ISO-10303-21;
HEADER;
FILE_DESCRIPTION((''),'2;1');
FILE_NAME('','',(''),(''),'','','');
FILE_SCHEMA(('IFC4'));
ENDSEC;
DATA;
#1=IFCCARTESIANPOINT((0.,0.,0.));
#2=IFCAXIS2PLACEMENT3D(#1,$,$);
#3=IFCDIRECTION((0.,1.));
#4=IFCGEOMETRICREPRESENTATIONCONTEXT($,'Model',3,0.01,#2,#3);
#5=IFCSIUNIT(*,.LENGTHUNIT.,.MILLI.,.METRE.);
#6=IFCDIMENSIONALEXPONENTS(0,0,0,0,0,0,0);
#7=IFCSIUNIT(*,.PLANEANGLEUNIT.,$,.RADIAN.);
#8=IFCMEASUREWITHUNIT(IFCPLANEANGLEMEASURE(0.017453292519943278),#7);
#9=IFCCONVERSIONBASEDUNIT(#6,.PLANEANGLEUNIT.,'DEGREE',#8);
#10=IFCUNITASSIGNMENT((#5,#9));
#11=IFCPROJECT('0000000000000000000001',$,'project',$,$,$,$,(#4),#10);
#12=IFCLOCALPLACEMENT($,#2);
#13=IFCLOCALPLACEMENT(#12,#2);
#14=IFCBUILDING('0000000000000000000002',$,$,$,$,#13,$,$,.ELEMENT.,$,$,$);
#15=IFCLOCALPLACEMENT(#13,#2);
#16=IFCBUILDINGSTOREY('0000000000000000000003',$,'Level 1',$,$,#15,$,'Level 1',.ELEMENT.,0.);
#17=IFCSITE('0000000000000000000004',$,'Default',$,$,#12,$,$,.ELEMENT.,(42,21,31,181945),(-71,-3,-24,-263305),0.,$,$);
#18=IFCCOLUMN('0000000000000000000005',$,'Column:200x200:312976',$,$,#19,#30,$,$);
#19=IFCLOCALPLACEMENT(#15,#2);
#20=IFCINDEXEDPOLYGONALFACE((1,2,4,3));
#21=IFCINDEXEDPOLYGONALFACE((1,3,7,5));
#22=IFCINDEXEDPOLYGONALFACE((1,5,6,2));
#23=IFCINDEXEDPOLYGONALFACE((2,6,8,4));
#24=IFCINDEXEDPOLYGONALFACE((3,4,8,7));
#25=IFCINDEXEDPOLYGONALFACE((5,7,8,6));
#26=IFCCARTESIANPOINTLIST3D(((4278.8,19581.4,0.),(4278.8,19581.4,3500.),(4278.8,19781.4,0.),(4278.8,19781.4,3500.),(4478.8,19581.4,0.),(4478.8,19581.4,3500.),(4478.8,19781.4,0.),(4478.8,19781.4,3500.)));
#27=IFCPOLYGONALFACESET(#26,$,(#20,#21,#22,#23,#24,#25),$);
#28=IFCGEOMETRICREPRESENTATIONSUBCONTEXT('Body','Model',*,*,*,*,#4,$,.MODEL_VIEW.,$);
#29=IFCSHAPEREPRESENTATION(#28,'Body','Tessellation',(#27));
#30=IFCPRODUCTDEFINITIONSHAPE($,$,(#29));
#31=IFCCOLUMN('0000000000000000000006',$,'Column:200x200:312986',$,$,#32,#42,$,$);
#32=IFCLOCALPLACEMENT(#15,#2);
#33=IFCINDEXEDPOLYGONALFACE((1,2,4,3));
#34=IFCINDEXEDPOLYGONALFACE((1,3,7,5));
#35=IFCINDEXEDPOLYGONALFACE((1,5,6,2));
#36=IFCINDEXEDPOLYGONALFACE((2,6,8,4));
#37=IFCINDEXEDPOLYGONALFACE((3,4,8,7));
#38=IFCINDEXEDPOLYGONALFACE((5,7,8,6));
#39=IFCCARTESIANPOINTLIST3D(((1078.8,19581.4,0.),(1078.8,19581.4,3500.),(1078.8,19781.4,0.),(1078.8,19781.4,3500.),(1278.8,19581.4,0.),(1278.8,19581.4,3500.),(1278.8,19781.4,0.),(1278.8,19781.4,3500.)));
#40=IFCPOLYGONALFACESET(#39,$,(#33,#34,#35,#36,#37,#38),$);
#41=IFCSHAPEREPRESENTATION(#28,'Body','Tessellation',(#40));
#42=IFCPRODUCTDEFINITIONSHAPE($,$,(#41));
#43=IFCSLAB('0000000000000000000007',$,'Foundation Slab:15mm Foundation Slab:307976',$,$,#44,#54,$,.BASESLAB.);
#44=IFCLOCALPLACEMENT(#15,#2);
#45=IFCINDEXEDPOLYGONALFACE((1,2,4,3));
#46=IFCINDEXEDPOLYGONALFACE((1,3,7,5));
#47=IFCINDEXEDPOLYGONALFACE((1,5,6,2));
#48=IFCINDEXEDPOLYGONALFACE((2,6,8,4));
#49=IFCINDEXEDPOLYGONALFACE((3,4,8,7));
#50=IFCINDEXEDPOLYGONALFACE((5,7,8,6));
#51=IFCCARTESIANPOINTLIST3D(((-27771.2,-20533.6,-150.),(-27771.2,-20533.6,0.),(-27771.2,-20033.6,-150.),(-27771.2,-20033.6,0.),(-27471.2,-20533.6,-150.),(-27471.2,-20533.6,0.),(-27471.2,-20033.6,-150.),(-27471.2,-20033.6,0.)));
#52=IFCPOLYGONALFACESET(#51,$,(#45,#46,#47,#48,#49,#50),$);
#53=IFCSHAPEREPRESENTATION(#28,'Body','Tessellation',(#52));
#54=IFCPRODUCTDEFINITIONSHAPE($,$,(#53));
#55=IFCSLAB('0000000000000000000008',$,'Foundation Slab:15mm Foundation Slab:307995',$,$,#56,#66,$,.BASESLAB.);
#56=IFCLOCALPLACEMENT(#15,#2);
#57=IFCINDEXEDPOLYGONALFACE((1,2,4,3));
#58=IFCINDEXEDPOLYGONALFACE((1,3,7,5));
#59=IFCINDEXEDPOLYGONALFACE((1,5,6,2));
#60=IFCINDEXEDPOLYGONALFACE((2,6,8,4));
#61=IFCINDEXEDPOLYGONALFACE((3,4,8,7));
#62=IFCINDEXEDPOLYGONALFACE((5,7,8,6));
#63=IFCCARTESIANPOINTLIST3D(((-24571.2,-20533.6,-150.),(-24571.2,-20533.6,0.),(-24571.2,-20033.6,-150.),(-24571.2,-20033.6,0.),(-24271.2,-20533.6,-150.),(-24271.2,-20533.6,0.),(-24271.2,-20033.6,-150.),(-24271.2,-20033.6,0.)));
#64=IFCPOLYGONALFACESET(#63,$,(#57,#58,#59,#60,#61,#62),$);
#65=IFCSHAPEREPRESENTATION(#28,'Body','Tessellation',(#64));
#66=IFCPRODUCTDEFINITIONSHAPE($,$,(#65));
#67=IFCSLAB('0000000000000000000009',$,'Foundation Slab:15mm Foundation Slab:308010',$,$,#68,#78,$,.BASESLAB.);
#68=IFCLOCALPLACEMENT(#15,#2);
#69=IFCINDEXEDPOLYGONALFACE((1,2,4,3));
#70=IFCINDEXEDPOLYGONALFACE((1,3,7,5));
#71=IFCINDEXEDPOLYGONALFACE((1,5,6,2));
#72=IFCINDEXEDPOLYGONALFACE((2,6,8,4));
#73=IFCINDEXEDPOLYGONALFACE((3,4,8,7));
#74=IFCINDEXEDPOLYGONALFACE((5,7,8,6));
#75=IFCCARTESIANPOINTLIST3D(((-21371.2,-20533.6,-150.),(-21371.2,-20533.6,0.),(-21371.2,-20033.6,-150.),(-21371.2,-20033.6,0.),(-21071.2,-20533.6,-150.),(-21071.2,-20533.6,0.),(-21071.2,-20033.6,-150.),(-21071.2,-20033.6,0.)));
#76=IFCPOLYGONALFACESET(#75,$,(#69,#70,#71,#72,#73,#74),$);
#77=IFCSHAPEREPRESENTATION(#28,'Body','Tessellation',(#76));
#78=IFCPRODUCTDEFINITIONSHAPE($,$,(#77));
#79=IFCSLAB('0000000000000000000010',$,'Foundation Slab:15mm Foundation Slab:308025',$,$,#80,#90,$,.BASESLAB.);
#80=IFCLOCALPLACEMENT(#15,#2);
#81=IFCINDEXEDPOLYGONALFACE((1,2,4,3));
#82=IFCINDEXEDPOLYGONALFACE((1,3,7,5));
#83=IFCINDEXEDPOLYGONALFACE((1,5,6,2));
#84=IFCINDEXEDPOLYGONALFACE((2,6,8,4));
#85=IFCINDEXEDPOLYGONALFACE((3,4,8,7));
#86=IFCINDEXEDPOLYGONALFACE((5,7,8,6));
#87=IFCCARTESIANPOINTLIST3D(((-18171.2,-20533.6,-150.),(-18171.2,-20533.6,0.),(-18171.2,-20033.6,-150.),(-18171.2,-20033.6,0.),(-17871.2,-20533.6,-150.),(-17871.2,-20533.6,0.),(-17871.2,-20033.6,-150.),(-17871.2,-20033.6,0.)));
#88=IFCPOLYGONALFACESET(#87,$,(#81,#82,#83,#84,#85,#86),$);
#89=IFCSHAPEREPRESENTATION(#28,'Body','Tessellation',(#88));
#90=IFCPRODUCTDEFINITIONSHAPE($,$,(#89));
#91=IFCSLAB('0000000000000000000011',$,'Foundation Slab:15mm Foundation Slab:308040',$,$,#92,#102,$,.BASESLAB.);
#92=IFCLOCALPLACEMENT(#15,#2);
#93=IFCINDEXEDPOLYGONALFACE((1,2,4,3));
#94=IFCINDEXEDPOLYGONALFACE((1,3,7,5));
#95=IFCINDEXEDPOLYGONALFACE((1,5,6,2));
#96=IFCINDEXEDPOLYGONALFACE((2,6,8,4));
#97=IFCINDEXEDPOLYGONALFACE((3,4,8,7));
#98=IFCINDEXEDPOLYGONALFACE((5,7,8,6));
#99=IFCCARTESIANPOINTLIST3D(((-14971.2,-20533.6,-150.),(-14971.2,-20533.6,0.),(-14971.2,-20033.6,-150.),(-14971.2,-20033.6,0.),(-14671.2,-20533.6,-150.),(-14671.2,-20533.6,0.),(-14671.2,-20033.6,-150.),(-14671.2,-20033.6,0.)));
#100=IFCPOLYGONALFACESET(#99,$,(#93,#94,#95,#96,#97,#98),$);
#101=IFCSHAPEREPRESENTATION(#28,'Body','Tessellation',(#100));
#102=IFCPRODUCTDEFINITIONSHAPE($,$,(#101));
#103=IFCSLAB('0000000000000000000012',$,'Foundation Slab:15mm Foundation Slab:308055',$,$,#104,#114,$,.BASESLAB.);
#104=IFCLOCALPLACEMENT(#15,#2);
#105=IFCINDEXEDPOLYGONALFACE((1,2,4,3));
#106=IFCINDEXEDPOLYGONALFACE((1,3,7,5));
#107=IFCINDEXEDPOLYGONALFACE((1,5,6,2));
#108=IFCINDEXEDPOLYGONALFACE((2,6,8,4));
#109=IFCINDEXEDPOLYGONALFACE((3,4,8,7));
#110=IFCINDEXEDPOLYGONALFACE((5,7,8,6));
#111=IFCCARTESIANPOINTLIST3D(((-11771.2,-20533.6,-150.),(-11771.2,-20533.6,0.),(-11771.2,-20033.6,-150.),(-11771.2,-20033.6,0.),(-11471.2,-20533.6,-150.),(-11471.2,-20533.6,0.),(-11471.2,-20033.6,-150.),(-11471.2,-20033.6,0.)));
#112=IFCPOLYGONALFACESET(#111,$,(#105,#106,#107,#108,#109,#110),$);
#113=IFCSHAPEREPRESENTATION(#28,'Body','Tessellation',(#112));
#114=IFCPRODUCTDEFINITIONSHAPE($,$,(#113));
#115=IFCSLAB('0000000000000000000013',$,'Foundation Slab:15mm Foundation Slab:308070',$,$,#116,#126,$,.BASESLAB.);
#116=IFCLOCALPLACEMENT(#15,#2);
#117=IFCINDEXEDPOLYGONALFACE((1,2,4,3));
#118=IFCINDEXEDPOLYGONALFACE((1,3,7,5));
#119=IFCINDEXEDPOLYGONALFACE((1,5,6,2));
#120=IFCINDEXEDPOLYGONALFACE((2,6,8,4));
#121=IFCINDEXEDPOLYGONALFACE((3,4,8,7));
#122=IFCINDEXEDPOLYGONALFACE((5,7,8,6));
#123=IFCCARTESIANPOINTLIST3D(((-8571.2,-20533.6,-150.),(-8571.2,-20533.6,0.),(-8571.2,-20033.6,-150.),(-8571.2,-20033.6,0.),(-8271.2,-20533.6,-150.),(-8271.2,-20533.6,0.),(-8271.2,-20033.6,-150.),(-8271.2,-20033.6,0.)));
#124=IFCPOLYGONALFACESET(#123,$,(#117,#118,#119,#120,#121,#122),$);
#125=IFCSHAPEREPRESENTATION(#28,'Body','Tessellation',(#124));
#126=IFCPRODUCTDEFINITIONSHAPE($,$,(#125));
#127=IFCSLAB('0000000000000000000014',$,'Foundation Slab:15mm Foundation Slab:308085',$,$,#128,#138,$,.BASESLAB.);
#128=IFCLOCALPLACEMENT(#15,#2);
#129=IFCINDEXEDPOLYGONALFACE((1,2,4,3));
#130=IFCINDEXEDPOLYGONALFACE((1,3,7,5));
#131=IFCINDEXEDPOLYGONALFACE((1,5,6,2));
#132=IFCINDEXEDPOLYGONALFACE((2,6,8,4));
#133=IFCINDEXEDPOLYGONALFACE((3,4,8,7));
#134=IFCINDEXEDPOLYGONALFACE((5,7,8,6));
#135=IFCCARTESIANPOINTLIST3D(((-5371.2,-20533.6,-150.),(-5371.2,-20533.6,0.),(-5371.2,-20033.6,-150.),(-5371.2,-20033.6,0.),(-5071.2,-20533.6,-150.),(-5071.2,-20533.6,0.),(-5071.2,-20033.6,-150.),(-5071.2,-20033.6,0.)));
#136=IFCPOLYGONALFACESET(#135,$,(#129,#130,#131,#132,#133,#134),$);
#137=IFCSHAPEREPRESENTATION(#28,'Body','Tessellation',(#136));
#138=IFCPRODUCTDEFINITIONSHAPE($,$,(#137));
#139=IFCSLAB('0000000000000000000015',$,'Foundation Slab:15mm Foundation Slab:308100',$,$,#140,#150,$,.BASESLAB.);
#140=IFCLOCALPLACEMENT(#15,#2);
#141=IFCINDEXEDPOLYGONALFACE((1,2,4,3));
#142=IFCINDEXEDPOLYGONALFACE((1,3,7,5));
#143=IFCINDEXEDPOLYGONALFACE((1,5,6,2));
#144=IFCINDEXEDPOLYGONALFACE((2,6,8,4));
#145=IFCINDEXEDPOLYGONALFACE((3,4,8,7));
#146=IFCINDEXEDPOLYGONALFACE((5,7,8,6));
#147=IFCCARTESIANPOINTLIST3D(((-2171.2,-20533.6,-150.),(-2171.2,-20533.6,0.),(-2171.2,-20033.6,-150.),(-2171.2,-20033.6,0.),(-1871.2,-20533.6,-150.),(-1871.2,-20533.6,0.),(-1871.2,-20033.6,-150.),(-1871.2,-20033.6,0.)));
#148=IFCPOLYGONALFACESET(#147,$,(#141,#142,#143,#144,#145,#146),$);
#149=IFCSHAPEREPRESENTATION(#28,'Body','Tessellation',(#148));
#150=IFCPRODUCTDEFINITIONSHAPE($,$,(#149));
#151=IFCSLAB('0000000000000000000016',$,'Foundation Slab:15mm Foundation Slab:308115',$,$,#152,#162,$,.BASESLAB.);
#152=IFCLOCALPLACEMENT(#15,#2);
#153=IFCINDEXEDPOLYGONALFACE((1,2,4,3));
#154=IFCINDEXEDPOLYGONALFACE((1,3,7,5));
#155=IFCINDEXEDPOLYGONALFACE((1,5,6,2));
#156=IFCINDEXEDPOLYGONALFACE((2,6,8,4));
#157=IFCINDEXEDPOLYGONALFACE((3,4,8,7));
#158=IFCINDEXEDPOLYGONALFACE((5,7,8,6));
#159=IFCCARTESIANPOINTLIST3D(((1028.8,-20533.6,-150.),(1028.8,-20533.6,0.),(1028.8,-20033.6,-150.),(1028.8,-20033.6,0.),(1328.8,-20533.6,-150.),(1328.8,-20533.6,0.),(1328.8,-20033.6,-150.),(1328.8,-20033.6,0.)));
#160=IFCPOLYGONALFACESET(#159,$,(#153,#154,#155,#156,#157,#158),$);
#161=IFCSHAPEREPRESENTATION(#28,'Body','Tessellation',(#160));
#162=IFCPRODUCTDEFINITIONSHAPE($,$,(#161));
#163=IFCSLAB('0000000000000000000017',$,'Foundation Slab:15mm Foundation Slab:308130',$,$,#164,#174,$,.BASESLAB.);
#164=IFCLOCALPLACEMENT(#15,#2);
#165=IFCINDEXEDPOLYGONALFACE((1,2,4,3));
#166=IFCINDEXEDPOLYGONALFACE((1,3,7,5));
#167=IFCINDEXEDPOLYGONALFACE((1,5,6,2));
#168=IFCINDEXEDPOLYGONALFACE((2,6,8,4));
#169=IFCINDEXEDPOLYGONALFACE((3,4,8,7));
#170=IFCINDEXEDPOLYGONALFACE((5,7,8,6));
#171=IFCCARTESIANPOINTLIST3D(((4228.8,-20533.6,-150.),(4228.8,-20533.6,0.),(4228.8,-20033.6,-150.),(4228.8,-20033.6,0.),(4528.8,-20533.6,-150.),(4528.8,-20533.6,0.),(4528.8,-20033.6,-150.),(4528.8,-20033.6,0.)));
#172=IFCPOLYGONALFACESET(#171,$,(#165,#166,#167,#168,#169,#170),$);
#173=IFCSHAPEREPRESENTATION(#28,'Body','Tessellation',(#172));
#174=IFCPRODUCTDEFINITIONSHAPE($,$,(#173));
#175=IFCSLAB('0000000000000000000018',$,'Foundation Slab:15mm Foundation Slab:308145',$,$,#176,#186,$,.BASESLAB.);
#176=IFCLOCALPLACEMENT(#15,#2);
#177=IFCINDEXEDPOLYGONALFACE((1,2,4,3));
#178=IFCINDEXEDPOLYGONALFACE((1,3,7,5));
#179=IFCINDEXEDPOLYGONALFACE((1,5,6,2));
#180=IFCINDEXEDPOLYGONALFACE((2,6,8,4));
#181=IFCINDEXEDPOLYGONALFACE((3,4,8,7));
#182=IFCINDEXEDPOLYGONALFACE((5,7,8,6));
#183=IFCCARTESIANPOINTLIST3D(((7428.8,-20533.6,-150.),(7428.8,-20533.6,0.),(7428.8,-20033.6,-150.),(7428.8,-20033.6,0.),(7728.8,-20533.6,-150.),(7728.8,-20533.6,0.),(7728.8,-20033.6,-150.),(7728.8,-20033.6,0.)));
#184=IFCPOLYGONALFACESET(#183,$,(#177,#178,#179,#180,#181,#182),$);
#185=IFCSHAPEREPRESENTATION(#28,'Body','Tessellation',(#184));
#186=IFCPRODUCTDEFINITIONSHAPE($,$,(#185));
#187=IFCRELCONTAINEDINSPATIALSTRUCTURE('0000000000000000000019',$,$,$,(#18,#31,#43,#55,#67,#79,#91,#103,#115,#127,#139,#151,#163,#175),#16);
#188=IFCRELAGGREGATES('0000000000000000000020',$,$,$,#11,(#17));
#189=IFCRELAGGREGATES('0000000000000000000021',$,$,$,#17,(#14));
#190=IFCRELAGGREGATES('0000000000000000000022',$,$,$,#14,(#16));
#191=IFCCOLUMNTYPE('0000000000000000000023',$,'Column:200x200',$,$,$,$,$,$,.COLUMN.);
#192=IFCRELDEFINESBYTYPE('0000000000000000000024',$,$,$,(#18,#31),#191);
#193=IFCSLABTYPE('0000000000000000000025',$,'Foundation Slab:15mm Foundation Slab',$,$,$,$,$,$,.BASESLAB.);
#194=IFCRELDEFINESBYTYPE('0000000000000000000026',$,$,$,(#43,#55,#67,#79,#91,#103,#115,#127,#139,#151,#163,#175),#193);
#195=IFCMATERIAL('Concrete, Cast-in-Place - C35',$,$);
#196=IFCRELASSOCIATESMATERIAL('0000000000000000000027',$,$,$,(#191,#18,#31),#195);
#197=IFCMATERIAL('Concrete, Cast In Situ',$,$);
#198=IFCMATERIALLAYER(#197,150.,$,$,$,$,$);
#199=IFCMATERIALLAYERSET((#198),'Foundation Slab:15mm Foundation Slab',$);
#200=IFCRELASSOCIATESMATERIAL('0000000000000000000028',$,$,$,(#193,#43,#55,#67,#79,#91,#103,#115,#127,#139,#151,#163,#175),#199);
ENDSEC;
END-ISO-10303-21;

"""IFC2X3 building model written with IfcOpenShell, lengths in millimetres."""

from ifc_helpers import new_model, entity, si_unit, converted_unit, direction, frame, frame_2d, origin, origin_2d_with_axis, place, context, subcontext, project, spatial, rectangle, extrude, source, transform, mapped, material, layer, layer_set, layer_usage, type_object, type_shapes, element, save


model = new_model("IFC2X3")

# Units and contexts
model_context = context("Model", 3, precision=0.01, world=origin(), true_north=direction((0.0, 1.0)))
body_context = subcontext(model_context, "Body", "Model", "MODEL_VIEW")
ifc_project = project(units=[si_unit("LENGTHUNIT", "METRE", prefix="MILLI"), converted_unit("PLANEANGLEUNIT", "DEGREE", entity("IfcPlaneAngleMeasure", 0.017453292519943278), si_unit("PLANEANGLEUNIT", "RADIAN"), dimensions=[0, 0, 0, 0, 0, 0, 0])], contexts=[model_context])

# Site, building, storey
site_placement = place(None, origin())
site = spatial("IfcSite", under=ifc_project, at=site_placement, Name="Default", CompositionType="ELEMENT", RefLatitude=(42, 21, 31, 181945), RefLongitude=(-71, -3, -24, -263305), RefElevation=0.0)
building_placement = place(site_placement, origin())
building = spatial("IfcBuilding", under=site, at=building_placement, CompositionType="ELEMENT")
storey_placement = place(building_placement, origin())
storey = spatial("IfcBuildingStorey", under=building, at=storey_placement, Name="Level 1", LongName="Level 1", CompositionType="ELEMENT", Elevation=0.0)

# Columns
ifc_material_1 = material(Name="Concrete, Cast-in-Place - C35")
column_type_1 = type_object("IfcColumnType", Name="Column:200x200", PredefinedType="COLUMN", material=ifc_material_1)
shared_shape_1 = source(origin(), body_context, "Body", "SweptSolid", [
    extrude(rectangle(XDim=200.0, YDim=200.0, at=frame_2d((0.0, 0.0), x_axis=(1.0, 0.0))), frame((0.0, 0.0, 0.0), z_axis=(0.0, 0.0, 1.0), x_axis=(-1.0, 0.0, 0.0)), (0.0, 0.0, 1.0), 3500.0),
])
type_shapes(column_type_1, [shared_shape_1])
for number, where, name in (
    (1, (4378.8, 19681.4, 0.0), "Column:200x200:312976"),
    (2, (1178.8, 19681.4, 0.0), "Column:200x200:312986"),
):
    element("IfcColumn", number, at=place(storey_placement, frame(where)), inside=storey, type_object=column_type_1, material=ifc_material_1, Name=name, context=body_context, shape_type="MappedRepresentation", body=[
        mapped(shared_shape_1, transform((0.0, 0.0, 0.0), scale=1.0)),
    ])

# Slabs
ifc_material_2 = material(Name="Concrete, Cast In Situ")
ifc_layer = layer(ifc_material_2, 150.0)
ifc_layer_set = layer_set([ifc_layer], Name="Foundation Slab:15mm Foundation Slab")
ifc_layer_usage_1 = layer_usage(ifc_layer_set, "AXIS3", "POSITIVE", 0.0)
slab_type = type_object("IfcSlabType", Name="Foundation Slab:15mm Foundation Slab", PredefinedType="BASESLAB", material=ifc_layer_set)
slab_1_placement = place(storey_placement, origin())
element("IfcSlab", 3, at=slab_1_placement, inside=storey, type_object=slab_type, material=ifc_layer_usage_1, Name="Foundation Slab:15mm Foundation Slab:307976", PredefinedType="BASESLAB", context=body_context, shape_type="SweptSolid", body=[
    extrude(rectangle(XDim=500.0, YDim=300.0, at=origin_2d_with_axis()), frame((-27621.2, -20283.6, 0.0), z_axis=(0.0, 0.0, -1.0), x_axis=(0.0, 1.0, 0.0)), (0.0, 0.0, 1.0), 150.0),
])
ifc_layer_usage_2 = layer_usage(ifc_layer_set, "AXIS3", "POSITIVE", 0.0)
slab_2_placement = place(storey_placement, origin())
element("IfcSlab", 4, at=slab_2_placement, inside=storey, type_object=slab_type, material=ifc_layer_usage_2, Name="Foundation Slab:15mm Foundation Slab:307995", PredefinedType="BASESLAB", context=body_context, shape_type="SweptSolid", body=[
    extrude(rectangle(XDim=500.0, YDim=300.0, at=origin_2d_with_axis()), frame((-24421.2, -20283.6, 0.0), z_axis=(0.0, 0.0, -1.0), x_axis=(0.0, 1.0, 0.0)), (0.0, 0.0, 1.0), 150.0),
])
ifc_layer_usage_3 = layer_usage(ifc_layer_set, "AXIS3", "POSITIVE", 0.0)
slab_3_placement = place(storey_placement, origin())
element("IfcSlab", 5, at=slab_3_placement, inside=storey, type_object=slab_type, material=ifc_layer_usage_3, Name="Foundation Slab:15mm Foundation Slab:308010", PredefinedType="BASESLAB", context=body_context, shape_type="SweptSolid", body=[
    extrude(rectangle(XDim=500.0, YDim=300.0, at=origin_2d_with_axis()), frame((-21221.2, -20283.6, 0.0), z_axis=(0.0, 0.0, -1.0), x_axis=(0.0, 1.0, 0.0)), (0.0, 0.0, 1.0), 150.0),
])
ifc_layer_usage_4 = layer_usage(ifc_layer_set, "AXIS3", "POSITIVE", 0.0)
slab_4_placement = place(storey_placement, origin())
element("IfcSlab", 6, at=slab_4_placement, inside=storey, type_object=slab_type, material=ifc_layer_usage_4, Name="Foundation Slab:15mm Foundation Slab:308025", PredefinedType="BASESLAB", context=body_context, shape_type="SweptSolid", body=[
    extrude(rectangle(XDim=500.0, YDim=300.0, at=origin_2d_with_axis()), frame((-18021.2, -20283.6, 0.0), z_axis=(0.0, 0.0, -1.0), x_axis=(0.0, 1.0, 0.0)), (0.0, 0.0, 1.0), 150.0),
])
ifc_layer_usage_5 = layer_usage(ifc_layer_set, "AXIS3", "POSITIVE", 0.0)
slab_5_placement = place(storey_placement, origin())
element("IfcSlab", 7, at=slab_5_placement, inside=storey, type_object=slab_type, material=ifc_layer_usage_5, Name="Foundation Slab:15mm Foundation Slab:308040", PredefinedType="BASESLAB", context=body_context, shape_type="SweptSolid", body=[
    extrude(rectangle(XDim=500.0, YDim=300.0, at=origin_2d_with_axis()), frame((-14821.2, -20283.6, 0.0), z_axis=(0.0, 0.0, -1.0), x_axis=(0.0, 1.0, 0.0)), (0.0, 0.0, 1.0), 150.0),
])
ifc_layer_usage_6 = layer_usage(ifc_layer_set, "AXIS3", "POSITIVE", 0.0)
slab_6_placement = place(storey_placement, origin())
element("IfcSlab", 8, at=slab_6_placement, inside=storey, type_object=slab_type, material=ifc_layer_usage_6, Name="Foundation Slab:15mm Foundation Slab:308055", PredefinedType="BASESLAB", context=body_context, shape_type="SweptSolid", body=[
    extrude(rectangle(XDim=500.0, YDim=300.0, at=origin_2d_with_axis()), frame((-11621.2, -20283.6, 0.0), z_axis=(0.0, 0.0, -1.0), x_axis=(0.0, 1.0, 0.0)), (0.0, 0.0, 1.0), 150.0),
])
ifc_layer_usage_7 = layer_usage(ifc_layer_set, "AXIS3", "POSITIVE", 0.0)
slab_7_placement = place(storey_placement, origin())
element("IfcSlab", 9, at=slab_7_placement, inside=storey, type_object=slab_type, material=ifc_layer_usage_7, Name="Foundation Slab:15mm Foundation Slab:308070", PredefinedType="BASESLAB", context=body_context, shape_type="SweptSolid", body=[
    extrude(rectangle(XDim=500.0, YDim=300.0, at=origin_2d_with_axis()), frame((-8421.2, -20283.6, 0.0), z_axis=(0.0, 0.0, -1.0), x_axis=(0.0, 1.0, 0.0)), (0.0, 0.0, 1.0), 150.0),
])
ifc_layer_usage_8 = layer_usage(ifc_layer_set, "AXIS3", "POSITIVE", 0.0)
slab_8_placement = place(storey_placement, origin())
element("IfcSlab", 10, at=slab_8_placement, inside=storey, type_object=slab_type, material=ifc_layer_usage_8, Name="Foundation Slab:15mm Foundation Slab:308085", PredefinedType="BASESLAB", context=body_context, shape_type="SweptSolid", body=[
    extrude(rectangle(XDim=500.0, YDim=300.0, at=origin_2d_with_axis()), frame((-5221.2, -20283.6, 0.0), z_axis=(0.0, 0.0, -1.0), x_axis=(0.0, 1.0, 0.0)), (0.0, 0.0, 1.0), 150.0),
])
ifc_layer_usage_9 = layer_usage(ifc_layer_set, "AXIS3", "POSITIVE", 0.0)
slab_9_placement = place(storey_placement, origin())
element("IfcSlab", 11, at=slab_9_placement, inside=storey, type_object=slab_type, material=ifc_layer_usage_9, Name="Foundation Slab:15mm Foundation Slab:308100", PredefinedType="BASESLAB", context=body_context, shape_type="SweptSolid", body=[
    extrude(rectangle(XDim=500.0, YDim=300.0, at=origin_2d_with_axis()), frame((-2021.2, -20283.6, 0.0), z_axis=(0.0, 0.0, -1.0), x_axis=(0.0, 1.0, 0.0)), (0.0, 0.0, 1.0), 150.0),
])
ifc_layer_usage_10 = layer_usage(ifc_layer_set, "AXIS3", "POSITIVE", 0.0)
slab_10_placement = place(storey_placement, origin())
element("IfcSlab", 12, at=slab_10_placement, inside=storey, type_object=slab_type, material=ifc_layer_usage_10, Name="Foundation Slab:15mm Foundation Slab:308115", PredefinedType="BASESLAB", context=body_context, shape_type="SweptSolid", body=[
    extrude(rectangle(XDim=500.0, YDim=300.0, at=origin_2d_with_axis()), frame((1178.8, -20283.6, 0.0), z_axis=(0.0, 0.0, -1.0), x_axis=(0.0, 1.0, 0.0)), (0.0, 0.0, 1.0), 150.0),
])
ifc_layer_usage_11 = layer_usage(ifc_layer_set, "AXIS3", "POSITIVE", 0.0)
slab_11_placement = place(storey_placement, origin())
element("IfcSlab", 13, at=slab_11_placement, inside=storey, type_object=slab_type, material=ifc_layer_usage_11, Name="Foundation Slab:15mm Foundation Slab:308130", PredefinedType="BASESLAB", context=body_context, shape_type="SweptSolid", body=[
    extrude(rectangle(XDim=500.0, YDim=300.0, at=origin_2d_with_axis()), frame((4378.8, -20283.6, 0.0), z_axis=(0.0, 0.0, -1.0), x_axis=(0.0, 1.0, 0.0)), (0.0, 0.0, 1.0), 150.0),
])
ifc_layer_usage_12 = layer_usage(ifc_layer_set, "AXIS3", "POSITIVE", 0.0)
slab_12_placement = place(storey_placement, origin())
element("IfcSlab", 14, at=slab_12_placement, inside=storey, type_object=slab_type, material=ifc_layer_usage_12, Name="Foundation Slab:15mm Foundation Slab:308145", PredefinedType="BASESLAB", context=body_context, shape_type="SweptSolid", body=[
    extrude(rectangle(XDim=500.0, YDim=300.0, at=origin_2d_with_axis()), frame((7578.8, -20283.6, 0.0), z_axis=(0.0, 0.0, -1.0), x_axis=(0.0, 1.0, 0.0)), (0.0, 0.0, 1.0), 150.0),
])

save(model, "model.ifc")
